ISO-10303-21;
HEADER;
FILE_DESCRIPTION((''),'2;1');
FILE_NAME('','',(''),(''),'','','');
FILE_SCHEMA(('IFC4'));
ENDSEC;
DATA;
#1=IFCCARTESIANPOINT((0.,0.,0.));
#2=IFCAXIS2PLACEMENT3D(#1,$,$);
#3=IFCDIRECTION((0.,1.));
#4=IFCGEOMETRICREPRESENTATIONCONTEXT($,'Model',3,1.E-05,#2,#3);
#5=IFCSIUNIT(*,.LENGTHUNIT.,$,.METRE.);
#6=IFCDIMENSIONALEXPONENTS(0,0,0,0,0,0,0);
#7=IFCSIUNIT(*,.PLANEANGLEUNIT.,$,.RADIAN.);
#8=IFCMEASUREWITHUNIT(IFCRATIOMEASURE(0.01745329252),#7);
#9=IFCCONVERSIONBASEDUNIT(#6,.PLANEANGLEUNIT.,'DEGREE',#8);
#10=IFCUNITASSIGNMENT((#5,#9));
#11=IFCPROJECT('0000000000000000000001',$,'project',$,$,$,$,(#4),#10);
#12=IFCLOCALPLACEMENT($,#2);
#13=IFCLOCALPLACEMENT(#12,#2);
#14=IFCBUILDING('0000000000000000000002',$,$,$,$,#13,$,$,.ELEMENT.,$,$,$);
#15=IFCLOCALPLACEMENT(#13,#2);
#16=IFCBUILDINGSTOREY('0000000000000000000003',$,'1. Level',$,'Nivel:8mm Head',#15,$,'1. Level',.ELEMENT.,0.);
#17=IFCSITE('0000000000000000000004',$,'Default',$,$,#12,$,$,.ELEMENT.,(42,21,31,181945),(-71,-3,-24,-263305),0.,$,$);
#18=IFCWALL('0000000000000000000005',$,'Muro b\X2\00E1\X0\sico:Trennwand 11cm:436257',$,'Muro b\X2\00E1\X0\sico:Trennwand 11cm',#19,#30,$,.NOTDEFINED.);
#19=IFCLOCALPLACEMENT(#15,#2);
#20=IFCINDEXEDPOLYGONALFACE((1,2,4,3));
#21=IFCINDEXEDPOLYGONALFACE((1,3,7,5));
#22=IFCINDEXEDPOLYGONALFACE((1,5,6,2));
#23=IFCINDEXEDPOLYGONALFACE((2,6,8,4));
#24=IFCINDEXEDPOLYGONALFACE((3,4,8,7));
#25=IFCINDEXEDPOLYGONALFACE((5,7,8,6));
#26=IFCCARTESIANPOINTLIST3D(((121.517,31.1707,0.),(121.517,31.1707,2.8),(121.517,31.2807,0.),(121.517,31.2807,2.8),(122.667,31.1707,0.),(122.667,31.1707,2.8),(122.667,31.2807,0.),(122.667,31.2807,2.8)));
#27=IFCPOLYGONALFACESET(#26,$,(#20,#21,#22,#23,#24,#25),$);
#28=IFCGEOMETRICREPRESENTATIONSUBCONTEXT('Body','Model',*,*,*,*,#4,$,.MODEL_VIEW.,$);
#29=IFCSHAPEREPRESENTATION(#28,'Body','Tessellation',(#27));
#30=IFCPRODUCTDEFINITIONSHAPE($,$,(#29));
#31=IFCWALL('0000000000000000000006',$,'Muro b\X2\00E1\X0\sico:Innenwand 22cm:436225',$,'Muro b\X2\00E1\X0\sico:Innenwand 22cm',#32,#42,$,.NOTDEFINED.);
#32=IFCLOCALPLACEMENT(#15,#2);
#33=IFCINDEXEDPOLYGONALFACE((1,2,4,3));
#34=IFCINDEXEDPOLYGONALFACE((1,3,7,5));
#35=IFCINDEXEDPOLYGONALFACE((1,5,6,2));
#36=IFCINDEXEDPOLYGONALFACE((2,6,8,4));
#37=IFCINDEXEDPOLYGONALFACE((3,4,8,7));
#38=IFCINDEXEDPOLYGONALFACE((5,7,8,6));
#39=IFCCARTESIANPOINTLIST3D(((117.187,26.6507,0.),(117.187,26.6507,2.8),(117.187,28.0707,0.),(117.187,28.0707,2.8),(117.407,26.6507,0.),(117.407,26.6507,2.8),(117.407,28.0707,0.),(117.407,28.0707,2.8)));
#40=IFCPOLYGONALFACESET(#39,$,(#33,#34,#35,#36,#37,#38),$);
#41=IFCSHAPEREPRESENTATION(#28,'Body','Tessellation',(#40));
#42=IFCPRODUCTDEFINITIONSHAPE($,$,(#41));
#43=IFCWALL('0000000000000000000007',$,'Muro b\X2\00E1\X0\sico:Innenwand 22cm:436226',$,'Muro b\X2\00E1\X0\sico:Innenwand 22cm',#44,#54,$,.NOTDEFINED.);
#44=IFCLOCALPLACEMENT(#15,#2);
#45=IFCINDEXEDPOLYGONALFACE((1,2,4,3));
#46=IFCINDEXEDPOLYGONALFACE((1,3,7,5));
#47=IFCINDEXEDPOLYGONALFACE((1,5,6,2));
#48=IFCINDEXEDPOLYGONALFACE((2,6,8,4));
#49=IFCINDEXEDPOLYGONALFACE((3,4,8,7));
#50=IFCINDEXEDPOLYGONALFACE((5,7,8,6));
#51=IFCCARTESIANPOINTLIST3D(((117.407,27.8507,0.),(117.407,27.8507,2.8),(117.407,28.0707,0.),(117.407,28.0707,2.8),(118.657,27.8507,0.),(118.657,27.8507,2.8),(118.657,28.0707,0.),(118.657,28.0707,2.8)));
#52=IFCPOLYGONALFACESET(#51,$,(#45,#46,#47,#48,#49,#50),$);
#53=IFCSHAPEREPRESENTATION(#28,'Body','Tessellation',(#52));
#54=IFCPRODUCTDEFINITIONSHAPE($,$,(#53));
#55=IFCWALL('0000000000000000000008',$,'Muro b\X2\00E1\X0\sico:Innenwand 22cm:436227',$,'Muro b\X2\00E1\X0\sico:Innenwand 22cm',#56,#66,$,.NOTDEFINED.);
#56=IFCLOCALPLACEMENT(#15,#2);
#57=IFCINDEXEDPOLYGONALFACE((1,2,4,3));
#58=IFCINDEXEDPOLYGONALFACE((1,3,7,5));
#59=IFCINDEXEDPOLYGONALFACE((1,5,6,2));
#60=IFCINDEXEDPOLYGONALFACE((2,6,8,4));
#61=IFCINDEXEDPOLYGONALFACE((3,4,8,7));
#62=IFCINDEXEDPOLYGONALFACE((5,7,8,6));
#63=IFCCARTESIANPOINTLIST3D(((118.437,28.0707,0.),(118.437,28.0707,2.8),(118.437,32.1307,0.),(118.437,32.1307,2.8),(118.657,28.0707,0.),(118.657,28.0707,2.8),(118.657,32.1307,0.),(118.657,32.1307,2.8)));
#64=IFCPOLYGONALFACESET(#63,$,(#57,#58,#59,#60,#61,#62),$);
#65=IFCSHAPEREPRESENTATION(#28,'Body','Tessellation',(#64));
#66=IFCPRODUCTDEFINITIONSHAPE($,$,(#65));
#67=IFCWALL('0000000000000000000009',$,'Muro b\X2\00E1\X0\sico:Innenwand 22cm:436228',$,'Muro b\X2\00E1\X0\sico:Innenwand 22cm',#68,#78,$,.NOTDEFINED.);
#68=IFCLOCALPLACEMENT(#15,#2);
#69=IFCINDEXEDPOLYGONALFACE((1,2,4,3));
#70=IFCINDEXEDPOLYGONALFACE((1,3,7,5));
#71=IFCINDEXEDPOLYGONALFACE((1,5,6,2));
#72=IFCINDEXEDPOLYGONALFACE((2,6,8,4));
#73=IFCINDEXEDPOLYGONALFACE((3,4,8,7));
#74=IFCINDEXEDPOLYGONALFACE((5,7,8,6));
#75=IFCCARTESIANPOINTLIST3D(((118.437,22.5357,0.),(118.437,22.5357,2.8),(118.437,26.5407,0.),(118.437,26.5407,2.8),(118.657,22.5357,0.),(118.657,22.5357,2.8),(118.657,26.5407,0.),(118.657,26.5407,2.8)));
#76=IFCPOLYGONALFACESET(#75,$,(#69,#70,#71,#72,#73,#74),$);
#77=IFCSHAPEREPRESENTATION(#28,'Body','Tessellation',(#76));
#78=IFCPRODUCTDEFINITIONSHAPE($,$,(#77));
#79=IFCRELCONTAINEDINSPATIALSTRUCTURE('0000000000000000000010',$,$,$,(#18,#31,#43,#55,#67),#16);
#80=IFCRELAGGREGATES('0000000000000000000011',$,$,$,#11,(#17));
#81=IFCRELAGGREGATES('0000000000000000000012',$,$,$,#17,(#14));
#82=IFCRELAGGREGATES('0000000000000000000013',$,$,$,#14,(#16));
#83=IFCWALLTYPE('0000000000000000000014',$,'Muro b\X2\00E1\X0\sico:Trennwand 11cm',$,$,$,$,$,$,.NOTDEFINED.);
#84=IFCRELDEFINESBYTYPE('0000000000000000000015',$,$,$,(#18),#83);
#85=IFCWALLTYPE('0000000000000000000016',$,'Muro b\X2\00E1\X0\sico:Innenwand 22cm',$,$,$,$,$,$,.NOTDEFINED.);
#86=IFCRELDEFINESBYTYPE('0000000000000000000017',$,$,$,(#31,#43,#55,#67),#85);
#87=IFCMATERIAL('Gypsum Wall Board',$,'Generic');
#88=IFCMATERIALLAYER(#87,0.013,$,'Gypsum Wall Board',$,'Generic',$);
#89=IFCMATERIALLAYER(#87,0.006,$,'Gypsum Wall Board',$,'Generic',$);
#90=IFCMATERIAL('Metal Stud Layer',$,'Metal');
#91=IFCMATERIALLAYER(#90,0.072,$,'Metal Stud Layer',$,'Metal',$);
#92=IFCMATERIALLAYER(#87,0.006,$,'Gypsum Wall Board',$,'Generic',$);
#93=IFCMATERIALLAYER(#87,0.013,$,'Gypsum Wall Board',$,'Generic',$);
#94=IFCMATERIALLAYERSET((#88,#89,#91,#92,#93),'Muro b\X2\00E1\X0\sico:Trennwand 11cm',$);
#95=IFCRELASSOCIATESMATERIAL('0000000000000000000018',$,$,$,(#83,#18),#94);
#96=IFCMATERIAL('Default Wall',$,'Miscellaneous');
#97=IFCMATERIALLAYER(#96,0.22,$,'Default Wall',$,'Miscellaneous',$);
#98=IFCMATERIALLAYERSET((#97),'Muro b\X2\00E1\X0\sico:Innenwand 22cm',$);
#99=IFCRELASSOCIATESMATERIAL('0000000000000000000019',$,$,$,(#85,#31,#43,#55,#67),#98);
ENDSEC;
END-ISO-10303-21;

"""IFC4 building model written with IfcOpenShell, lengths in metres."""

from ifc_helpers import new_model, entity, si_unit, converted_unit, direction, frame, frame_2d, origin, place, context, subcontext, project, spatial, rectangle, extrude, material, layer, layer_set, layer_usage, type_object, element, save


model = new_model("IFC4")

# Units and contexts
model_context = context("Model", 3, precision=1e-05, world=origin(), true_north=direction((0.0, 1.0)))
body_context = subcontext(model_context, "Body", "Model", "MODEL_VIEW")
ifc_project = project(units=[si_unit("LENGTHUNIT", "METRE"), converted_unit("PLANEANGLEUNIT", "DEGREE", entity("IfcRatioMeasure", 0.01745329252), si_unit("PLANEANGLEUNIT", "RADIAN"), dimensions=[0, 0, 0, 0, 0, 0, 0])], contexts=[model_context])

# Site, building, storey
site_placement = place(None, origin())
site = spatial("IfcSite", under=ifc_project, at=site_placement, Name="Default", CompositionType="ELEMENT", RefLatitude=(42, 21, 31, 181945), RefLongitude=(-71, -3, -24, -263305), RefElevation=0.0)
building_placement = place(site_placement, origin())
building = spatial("IfcBuilding", under=site, at=building_placement, CompositionType="ELEMENT")
storey_placement = place(building_placement, origin())
storey = spatial("IfcBuildingStorey", under=building, at=storey_placement, Name="1. Level", ObjectType="Nivel:8mm Head", LongName="1. Level", CompositionType="ELEMENT", Elevation=0.0)

# Shared definitions
ifc_material_1 = material(Name="Gypsum Wall Board", Category="Generic")
ifc_layer_1 = layer(ifc_material_1, 0.013, Name="Gypsum Wall Board", Category="Generic")
ifc_layer_2 = layer(ifc_material_1, 0.006, Name="Gypsum Wall Board", Category="Generic")
ifc_material_2 = material(Name="Metal Stud Layer", Category="Metal")
ifc_layer_3 = layer(ifc_material_2, 0.072, Name="Metal Stud Layer", Category="Metal")
ifc_layer_4 = layer(ifc_material_1, 0.006, Name="Gypsum Wall Board", Category="Generic")
ifc_layer_5 = layer(ifc_material_1, 0.013, Name="Gypsum Wall Board", Category="Generic")
ifc_layer_set_1 = layer_set([ifc_layer_1, ifc_layer_2, ifc_layer_3, ifc_layer_4, ifc_layer_5], Name="Muro básico:Trennwand 11cm")
wall_type_1 = type_object("IfcWallType", Name="Muro básico:Trennwand 11cm", PredefinedType="NOTDEFINED", material=ifc_layer_set_1)

# Walls
ifc_layer_usage_1 = layer_usage(ifc_layer_set_1, "AXIS2", "NEGATIVE", 0.055)
wall_1_placement = place(storey_placement, frame((122.667, 31.2257, 0.0), z_axis=(0.0, 0.0, 1.0), x_axis=(-1.0, 0.0, 0.0)))
element("IfcWall", 1, at=wall_1_placement, inside=storey, type_object=wall_type_1, material=ifc_layer_usage_1, Name="Muro básico:Trennwand 11cm:436257", ObjectType="Muro básico:Trennwand 11cm", PredefinedType="NOTDEFINED", context=body_context, shape_type="SweptSolid", body=[
    extrude(rectangle(XDim=1.15, YDim=0.11, at=frame_2d((0.575, 0.0), x_axis=(-1.0, 0.0))), origin(), (0.0, 0.0, 1.0), 2.8),
])
ifc_material_3 = material(Name="Default Wall", Category="Miscellaneous")
ifc_layer_6 = layer(ifc_material_3, 0.22, Name="Default Wall", Category="Miscellaneous")
ifc_layer_set_2 = layer_set([ifc_layer_6], Name="Muro básico:Innenwand 22cm")
ifc_layer_usage_2 = layer_usage(ifc_layer_set_2, "AXIS2", "NEGATIVE", 0.11)
wall_type_2 = type_object("IfcWallType", Name="Muro básico:Innenwand 22cm", PredefinedType="NOTDEFINED", material=ifc_layer_set_2)
wall_2_placement = place(storey_placement, frame((117.297, 26.6507, 0.0), z_axis=(0.0, 0.0, 1.0), x_axis=(0.0, 1.0, 0.0)))
element("IfcWall", 2, at=wall_2_placement, inside=storey, type_object=wall_type_2, material=ifc_layer_usage_2, Name="Muro básico:Innenwand 22cm:436225", ObjectType="Muro básico:Innenwand 22cm", PredefinedType="NOTDEFINED", context=body_context, shape_type="SweptSolid", body=[
    extrude(rectangle(XDim=1.42, YDim=0.22, at=frame_2d((0.71, 0.0), x_axis=(-1.0, 0.0))), origin(), (0.0, 0.0, 1.0), 2.8),
])
ifc_layer_usage_3 = layer_usage(ifc_layer_set_2, "AXIS2", "NEGATIVE", 0.11)
wall_3_placement = place(storey_placement, frame((117.407, 27.9607, 0.0)))
element("IfcWall", 3, at=wall_3_placement, inside=storey, type_object=wall_type_2, material=ifc_layer_usage_3, Name="Muro básico:Innenwand 22cm:436226", ObjectType="Muro básico:Innenwand 22cm", PredefinedType="NOTDEFINED", context=body_context, shape_type="SweptSolid", body=[
    extrude(rectangle(XDim=1.25, YDim=0.22, at=frame_2d((0.625, 0.0), x_axis=(-1.0, 0.0))), origin(), (0.0, 0.0, 1.0), 2.8),
])
ifc_layer_usage_4 = layer_usage(ifc_layer_set_2, "AXIS2", "NEGATIVE", 0.11)
wall_4_placement = place(storey_placement, frame((118.547, 28.0707, 0.0), z_axis=(0.0, 0.0, 1.0), x_axis=(0.0, 1.0, 0.0)))
element("IfcWall", 4, at=wall_4_placement, inside=storey, type_object=wall_type_2, material=ifc_layer_usage_4, Name="Muro básico:Innenwand 22cm:436227", ObjectType="Muro básico:Innenwand 22cm", PredefinedType="NOTDEFINED", context=body_context, shape_type="SweptSolid", body=[
    extrude(rectangle(XDim=4.06, YDim=0.22, at=frame_2d((2.03, 0.0), x_axis=(-1.0, 0.0))), origin(), (0.0, 0.0, 1.0), 2.8),
])
ifc_layer_usage_5 = layer_usage(ifc_layer_set_2, "AXIS2", "NEGATIVE", 0.11)
wall_5_placement = place(storey_placement, frame((118.547, 22.5357, 0.0), z_axis=(0.0, 0.0, 1.0), x_axis=(0.0, 1.0, 0.0)))
element("IfcWall", 5, at=wall_5_placement, inside=storey, type_object=wall_type_2, material=ifc_layer_usage_5, Name="Muro básico:Innenwand 22cm:436228", ObjectType="Muro básico:Innenwand 22cm", PredefinedType="NOTDEFINED", context=body_context, shape_type="SweptSolid", body=[
    extrude(rectangle(XDim=4.005, YDim=0.22, at=frame_2d((2.0025, 0.0), x_axis=(-1.0, 0.0))), origin(), (0.0, 0.0, 1.0), 2.8),
])

save(model, "model.ifc")
